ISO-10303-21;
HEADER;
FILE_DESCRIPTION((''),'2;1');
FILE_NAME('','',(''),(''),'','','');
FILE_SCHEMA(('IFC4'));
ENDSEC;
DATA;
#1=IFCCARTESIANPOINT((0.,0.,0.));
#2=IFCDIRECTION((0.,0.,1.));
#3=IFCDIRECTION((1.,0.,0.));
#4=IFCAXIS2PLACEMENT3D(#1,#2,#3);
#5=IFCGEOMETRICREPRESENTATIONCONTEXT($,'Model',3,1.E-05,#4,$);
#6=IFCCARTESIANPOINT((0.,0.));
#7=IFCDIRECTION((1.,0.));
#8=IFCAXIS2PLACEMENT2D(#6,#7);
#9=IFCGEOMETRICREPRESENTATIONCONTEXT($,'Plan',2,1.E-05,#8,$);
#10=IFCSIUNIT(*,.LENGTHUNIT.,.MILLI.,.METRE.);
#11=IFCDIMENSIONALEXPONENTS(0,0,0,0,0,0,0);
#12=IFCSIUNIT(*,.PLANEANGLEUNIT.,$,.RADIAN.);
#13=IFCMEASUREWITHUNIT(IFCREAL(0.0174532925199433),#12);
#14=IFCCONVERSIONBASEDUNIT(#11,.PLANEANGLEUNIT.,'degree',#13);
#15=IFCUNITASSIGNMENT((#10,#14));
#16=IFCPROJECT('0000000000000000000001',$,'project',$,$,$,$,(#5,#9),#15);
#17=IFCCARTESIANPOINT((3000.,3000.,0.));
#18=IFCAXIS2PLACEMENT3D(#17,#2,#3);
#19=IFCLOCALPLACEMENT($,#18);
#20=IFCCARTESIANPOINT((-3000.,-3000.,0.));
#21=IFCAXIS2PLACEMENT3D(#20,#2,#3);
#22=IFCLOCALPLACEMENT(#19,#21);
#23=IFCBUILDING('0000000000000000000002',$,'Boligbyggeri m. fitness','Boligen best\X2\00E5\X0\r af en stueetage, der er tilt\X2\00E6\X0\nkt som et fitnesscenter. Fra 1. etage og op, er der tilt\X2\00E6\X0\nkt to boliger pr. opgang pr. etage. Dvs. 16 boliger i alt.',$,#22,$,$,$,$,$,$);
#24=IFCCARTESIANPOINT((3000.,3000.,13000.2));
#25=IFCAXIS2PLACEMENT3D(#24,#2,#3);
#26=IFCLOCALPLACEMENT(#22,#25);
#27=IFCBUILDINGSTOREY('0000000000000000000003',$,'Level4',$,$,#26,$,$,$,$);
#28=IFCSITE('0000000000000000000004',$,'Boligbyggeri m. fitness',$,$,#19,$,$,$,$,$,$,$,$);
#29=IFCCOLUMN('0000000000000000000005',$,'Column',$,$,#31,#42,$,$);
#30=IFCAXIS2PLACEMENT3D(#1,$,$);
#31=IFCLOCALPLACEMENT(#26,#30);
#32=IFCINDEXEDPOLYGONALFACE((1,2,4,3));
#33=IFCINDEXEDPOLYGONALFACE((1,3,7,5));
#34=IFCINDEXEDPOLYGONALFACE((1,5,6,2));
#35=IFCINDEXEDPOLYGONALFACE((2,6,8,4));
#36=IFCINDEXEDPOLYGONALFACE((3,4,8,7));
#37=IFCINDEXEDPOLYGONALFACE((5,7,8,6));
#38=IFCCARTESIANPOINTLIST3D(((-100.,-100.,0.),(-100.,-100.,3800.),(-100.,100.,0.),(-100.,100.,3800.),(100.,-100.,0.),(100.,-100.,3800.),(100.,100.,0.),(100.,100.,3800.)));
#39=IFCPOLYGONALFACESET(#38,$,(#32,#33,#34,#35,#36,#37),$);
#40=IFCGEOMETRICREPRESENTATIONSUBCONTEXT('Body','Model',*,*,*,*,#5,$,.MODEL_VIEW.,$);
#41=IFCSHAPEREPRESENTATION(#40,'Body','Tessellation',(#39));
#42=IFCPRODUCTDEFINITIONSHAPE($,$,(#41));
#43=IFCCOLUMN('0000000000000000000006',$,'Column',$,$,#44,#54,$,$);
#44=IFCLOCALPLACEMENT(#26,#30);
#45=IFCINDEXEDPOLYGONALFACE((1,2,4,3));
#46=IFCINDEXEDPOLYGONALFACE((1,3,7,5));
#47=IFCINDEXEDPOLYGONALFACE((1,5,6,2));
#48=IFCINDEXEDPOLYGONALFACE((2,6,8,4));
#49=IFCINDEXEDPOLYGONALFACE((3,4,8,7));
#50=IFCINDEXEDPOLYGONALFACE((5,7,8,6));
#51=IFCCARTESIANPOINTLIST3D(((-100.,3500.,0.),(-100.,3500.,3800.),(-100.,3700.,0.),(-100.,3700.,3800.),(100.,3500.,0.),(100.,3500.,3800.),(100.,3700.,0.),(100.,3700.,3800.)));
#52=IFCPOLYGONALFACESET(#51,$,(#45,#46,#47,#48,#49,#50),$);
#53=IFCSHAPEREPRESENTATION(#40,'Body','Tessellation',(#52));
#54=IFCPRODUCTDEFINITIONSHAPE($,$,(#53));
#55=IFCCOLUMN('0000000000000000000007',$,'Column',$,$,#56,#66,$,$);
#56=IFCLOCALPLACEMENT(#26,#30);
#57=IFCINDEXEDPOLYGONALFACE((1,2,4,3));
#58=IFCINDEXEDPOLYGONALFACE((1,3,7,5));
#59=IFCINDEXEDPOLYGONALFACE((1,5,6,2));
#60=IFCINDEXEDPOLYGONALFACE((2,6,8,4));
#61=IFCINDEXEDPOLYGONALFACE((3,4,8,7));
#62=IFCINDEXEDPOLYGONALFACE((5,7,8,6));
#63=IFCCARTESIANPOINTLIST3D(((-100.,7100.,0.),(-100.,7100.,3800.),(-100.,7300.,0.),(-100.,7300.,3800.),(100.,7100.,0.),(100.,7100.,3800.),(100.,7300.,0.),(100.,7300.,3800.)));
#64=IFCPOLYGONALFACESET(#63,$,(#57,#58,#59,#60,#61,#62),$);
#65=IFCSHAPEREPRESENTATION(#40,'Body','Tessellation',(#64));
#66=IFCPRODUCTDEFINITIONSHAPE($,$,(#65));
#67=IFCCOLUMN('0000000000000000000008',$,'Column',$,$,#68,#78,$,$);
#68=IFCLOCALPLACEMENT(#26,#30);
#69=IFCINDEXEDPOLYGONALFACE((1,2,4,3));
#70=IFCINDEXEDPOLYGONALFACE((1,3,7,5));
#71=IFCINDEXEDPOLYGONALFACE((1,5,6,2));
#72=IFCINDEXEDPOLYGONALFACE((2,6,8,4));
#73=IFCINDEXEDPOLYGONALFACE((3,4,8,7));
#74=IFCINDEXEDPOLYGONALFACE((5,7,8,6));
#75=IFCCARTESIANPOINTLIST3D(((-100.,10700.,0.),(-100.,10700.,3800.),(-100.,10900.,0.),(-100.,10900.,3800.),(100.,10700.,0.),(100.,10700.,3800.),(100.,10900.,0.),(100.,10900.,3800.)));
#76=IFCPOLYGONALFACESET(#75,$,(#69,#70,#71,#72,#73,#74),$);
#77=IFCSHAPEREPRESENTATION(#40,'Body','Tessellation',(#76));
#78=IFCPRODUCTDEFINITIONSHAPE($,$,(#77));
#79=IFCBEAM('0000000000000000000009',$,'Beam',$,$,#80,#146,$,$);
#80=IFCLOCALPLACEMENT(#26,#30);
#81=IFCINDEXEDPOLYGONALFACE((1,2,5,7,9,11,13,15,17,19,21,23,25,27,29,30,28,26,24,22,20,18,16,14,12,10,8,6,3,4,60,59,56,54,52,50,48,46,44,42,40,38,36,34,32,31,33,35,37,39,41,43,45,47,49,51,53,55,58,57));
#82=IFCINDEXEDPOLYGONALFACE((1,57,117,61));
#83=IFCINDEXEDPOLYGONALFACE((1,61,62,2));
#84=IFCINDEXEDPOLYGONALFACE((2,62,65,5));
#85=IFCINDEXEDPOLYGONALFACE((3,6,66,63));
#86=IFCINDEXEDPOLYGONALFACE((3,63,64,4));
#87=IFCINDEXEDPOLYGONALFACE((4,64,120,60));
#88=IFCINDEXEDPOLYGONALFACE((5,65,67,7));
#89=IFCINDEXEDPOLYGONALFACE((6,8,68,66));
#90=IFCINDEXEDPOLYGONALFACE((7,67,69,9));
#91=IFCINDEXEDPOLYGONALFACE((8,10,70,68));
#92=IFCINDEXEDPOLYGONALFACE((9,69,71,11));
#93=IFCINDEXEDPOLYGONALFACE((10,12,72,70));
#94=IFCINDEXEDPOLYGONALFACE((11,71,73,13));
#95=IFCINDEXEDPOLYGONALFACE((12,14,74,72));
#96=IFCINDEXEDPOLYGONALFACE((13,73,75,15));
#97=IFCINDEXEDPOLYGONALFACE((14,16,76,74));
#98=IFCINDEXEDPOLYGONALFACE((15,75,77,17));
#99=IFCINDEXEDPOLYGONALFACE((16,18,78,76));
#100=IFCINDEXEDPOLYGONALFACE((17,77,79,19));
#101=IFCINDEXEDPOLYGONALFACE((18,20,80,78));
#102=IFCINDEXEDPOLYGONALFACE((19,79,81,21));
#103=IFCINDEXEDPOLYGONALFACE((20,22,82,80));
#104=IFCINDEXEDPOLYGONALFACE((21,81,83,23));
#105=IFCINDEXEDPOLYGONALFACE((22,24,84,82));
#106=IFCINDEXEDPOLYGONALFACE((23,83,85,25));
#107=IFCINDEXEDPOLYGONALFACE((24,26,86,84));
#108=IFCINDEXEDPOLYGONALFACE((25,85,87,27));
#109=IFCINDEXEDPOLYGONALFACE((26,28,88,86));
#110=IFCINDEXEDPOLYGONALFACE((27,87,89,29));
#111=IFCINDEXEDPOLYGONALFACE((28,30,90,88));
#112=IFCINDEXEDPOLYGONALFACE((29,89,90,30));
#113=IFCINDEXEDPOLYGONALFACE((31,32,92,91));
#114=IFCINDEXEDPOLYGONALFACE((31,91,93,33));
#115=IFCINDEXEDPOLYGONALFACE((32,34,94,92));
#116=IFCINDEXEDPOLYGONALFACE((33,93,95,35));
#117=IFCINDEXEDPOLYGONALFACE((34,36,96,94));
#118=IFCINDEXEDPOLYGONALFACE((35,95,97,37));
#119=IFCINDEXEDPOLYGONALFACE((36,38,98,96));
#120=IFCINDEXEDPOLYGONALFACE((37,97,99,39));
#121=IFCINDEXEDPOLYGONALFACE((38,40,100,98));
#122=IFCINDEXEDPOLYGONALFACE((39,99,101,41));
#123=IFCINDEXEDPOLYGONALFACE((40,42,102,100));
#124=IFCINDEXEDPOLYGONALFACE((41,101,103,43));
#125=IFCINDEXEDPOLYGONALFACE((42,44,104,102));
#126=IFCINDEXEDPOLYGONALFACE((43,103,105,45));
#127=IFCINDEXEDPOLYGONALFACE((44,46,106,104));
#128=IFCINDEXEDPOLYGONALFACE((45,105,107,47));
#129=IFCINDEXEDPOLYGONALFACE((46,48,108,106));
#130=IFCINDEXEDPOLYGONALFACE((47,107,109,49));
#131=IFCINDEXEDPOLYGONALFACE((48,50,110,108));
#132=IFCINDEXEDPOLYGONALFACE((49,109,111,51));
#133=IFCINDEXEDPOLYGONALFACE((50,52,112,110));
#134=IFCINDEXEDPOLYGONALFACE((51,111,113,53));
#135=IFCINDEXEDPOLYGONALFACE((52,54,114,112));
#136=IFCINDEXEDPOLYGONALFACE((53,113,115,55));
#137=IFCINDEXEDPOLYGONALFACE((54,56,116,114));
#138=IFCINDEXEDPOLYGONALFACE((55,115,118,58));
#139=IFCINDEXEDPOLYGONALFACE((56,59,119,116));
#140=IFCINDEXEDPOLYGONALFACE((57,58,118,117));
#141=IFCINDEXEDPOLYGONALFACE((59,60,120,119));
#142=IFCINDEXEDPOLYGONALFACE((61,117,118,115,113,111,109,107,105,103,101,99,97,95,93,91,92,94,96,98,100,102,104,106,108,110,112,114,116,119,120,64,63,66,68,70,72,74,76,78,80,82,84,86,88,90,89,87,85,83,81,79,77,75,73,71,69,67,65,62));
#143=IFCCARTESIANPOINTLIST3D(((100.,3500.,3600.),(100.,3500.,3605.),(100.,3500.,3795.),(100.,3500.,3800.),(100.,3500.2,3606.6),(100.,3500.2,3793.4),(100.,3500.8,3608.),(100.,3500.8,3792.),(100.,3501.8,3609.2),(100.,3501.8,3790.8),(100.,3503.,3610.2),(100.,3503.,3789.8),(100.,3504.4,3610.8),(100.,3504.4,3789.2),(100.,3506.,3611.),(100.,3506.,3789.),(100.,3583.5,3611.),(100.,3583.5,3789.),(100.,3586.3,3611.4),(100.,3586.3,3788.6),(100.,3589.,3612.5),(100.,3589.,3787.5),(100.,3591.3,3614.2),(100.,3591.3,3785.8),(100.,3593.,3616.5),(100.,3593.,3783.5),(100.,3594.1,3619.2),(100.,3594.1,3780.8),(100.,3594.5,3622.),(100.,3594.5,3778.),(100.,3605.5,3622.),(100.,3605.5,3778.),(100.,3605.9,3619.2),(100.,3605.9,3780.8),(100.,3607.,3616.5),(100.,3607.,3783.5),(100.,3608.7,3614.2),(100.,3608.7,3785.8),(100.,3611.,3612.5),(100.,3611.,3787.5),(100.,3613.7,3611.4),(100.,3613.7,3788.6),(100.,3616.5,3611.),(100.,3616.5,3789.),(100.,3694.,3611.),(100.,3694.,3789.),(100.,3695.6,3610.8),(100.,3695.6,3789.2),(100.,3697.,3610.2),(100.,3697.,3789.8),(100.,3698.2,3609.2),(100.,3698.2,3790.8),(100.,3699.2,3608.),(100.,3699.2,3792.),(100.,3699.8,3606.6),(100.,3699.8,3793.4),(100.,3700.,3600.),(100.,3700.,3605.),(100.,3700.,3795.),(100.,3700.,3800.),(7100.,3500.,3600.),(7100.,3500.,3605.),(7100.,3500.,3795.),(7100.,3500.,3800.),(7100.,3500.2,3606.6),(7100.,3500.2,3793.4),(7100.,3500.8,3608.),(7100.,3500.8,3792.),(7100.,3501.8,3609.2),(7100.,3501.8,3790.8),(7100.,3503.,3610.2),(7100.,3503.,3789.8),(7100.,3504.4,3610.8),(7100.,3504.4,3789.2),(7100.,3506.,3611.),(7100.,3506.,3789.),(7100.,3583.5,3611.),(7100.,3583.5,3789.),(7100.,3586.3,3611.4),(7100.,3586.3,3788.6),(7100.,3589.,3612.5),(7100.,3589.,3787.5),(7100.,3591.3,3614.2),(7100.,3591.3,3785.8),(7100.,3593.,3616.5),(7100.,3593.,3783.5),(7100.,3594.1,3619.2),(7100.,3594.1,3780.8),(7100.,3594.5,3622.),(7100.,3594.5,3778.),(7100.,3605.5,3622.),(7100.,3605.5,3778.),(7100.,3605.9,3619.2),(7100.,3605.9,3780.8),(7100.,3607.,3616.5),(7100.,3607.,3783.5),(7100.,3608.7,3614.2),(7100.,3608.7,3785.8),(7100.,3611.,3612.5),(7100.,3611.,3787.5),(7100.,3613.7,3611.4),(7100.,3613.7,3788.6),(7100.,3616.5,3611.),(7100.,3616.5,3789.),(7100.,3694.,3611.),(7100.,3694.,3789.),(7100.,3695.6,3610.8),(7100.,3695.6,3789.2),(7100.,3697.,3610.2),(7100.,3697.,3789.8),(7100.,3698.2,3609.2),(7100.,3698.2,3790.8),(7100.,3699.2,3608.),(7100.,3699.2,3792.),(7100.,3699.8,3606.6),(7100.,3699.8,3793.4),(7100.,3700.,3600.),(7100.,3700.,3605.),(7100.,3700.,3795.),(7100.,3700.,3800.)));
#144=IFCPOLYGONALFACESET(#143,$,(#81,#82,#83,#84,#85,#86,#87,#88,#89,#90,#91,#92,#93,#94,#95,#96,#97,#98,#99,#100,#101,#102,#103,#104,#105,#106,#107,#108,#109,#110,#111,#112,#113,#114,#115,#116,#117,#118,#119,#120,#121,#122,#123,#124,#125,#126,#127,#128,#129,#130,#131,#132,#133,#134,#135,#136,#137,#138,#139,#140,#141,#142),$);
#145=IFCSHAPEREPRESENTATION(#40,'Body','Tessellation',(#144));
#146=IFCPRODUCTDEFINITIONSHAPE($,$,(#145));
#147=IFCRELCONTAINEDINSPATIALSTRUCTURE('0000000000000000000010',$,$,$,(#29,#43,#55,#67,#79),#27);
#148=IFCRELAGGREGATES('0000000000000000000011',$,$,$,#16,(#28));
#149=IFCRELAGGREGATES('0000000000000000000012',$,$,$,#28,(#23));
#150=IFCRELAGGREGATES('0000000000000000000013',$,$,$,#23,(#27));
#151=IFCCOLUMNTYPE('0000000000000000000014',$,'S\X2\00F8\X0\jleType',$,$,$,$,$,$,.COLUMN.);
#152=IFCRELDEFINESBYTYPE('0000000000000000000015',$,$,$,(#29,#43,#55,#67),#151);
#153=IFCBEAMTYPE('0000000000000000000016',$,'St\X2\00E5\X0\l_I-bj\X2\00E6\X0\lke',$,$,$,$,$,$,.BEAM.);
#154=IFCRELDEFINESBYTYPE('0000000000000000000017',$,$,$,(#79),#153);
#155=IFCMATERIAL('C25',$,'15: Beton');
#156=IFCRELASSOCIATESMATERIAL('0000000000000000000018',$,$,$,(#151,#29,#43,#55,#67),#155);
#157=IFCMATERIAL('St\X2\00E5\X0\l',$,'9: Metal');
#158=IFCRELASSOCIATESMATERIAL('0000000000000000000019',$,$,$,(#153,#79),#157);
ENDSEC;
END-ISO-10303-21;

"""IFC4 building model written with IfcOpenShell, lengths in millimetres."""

from ifc_helpers import new_model, entity, si_unit, converted_unit, frame, origin_with_axes, origin_2d_with_axis, place, context, subcontext, project, spatial, rectangle, i_section, extrude, material, material_profile, profile_set, profile_usage, type_object, element, save


model = new_model("IFC4")

# Units and contexts
model_context = context("Model", 3, precision=1e-05, world=origin_with_axes())
plan_context = context("Plan", 2, precision=1e-05, world=origin_2d_with_axis())
body_context = subcontext(model_context, "Body", "Model", "MODEL_VIEW")
ifc_project = project(units=[si_unit("LENGTHUNIT", "METRE", prefix="MILLI"), converted_unit("PLANEANGLEUNIT", "degree", entity("IfcReal", 0.0174532925199433), si_unit("PLANEANGLEUNIT", "RADIAN"), dimensions=[0, 0, 0, 0, 0, 0, 0])], contexts=[model_context, plan_context])

# Site, building, storey
site_placement = place(None, frame((3000.0, 3000.0, 0.0), z_axis=(0.0, 0.0, 1.0), x_axis=(1.0, 0.0, 0.0)))
site = spatial("IfcSite", under=ifc_project, at=site_placement, Name="Boligbyggeri m. fitness")
building_placement = place(site_placement, frame((-3000.0, -3000.0, 0.0), z_axis=(0.0, 0.0, 1.0), x_axis=(1.0, 0.0, 0.0)))
building = spatial("IfcBuilding", under=site, at=building_placement, Name="Boligbyggeri m. fitness", Description="Boligen består af en stueetage, der er tiltænkt som et fitnesscenter. Fra 1. etage og op, er der tiltænkt to boliger pr. opgang pr. etage. Dvs. 16 boliger i alt.")
storey_placement = place(building_placement, frame((3000.0, 3000.0, 13000.2), z_axis=(0.0, 0.0, 1.0), x_axis=(1.0, 0.0, 0.0)))
storey = spatial("IfcBuildingStorey", under=building, at=storey_placement, Name="Level4")

# Columns
ifc_material_1 = material(Name="C25", Category="15: Beton")
ifc_material_profile_1 = material_profile(ifc_material_1, rectangle(XDim=200.0, YDim=200.0), Name="SøjleBeton", Category="15: Beton")
ifc_profile_set_1 = profile_set([ifc_material_profile_1], Name="200x200")
ifc_profile_usage_1 = profile_usage(ifc_profile_set_1, cardinal=5)
column_type = type_object("IfcColumnType", Name="SøjleType", PredefinedType="COLUMN", material=ifc_profile_set_1)
column_1_placement = place(storey_placement, frame((0.0, 0.0, 0.0), z_axis=(0.0, 0.0, 1.0), x_axis=(1.0, 0.0, 0.0)))
element("IfcColumn", 1, at=column_1_placement, inside=storey, type_object=column_type, material=ifc_profile_usage_1, Name="Column", context=body_context, shape_type="SweptSolid", body=[
    extrude(rectangle(XDim=200.0, YDim=200.0), origin_with_axes(), (0.0, 0.0, 1.0), 3800.0),
])
ifc_profile_usage_2 = profile_usage(ifc_profile_set_1, cardinal=5)
column_2_placement = place(storey_placement, frame((0.0, 3600.0, 0.0), z_axis=(0.0, 0.0, 1.0), x_axis=(1.0, 0.0, 0.0)))
element("IfcColumn", 2, at=column_2_placement, inside=storey, type_object=column_type, material=ifc_profile_usage_2, Name="Column", context=body_context, shape_type="SweptSolid", body=[
    extrude(rectangle(XDim=200.0, YDim=200.0), origin_with_axes(), (0.0, 0.0, 1.0), 3800.0),
])
ifc_profile_usage_3 = profile_usage(ifc_profile_set_1, cardinal=5)
column_3_placement = place(storey_placement, frame((0.0, 7200.0, 0.0), z_axis=(0.0, 0.0, 1.0), x_axis=(1.0, 0.0, 0.0)))
element("IfcColumn", 3, at=column_3_placement, inside=storey, type_object=column_type, material=ifc_profile_usage_3, Name="Column", context=body_context, shape_type="SweptSolid", body=[
    extrude(rectangle(XDim=200.0, YDim=200.0), origin_with_axes(), (0.0, 0.0, 1.0), 3800.0),
])
ifc_profile_usage_4 = profile_usage(ifc_profile_set_1, cardinal=5)
column_4_placement = place(storey_placement, frame((0.0, 10800.0, 0.0), z_axis=(0.0, 0.0, 1.0), x_axis=(1.0, 0.0, 0.0)))
element("IfcColumn", 4, at=column_4_placement, inside=storey, type_object=column_type, material=ifc_profile_usage_4, Name="Column", context=body_context, shape_type="SweptSolid", body=[
    extrude(rectangle(XDim=200.0, YDim=200.0), origin_with_axes(), (0.0, 0.0, 1.0), 3800.0),
])

# Beam
ifc_material_2 = material(Name="Stål", Category="9: Metal")
ifc_material_profile_2 = material_profile(ifc_material_2, i_section(OverallWidth=200.0, OverallDepth=200.0, WebThickness=11.0, FlangeThickness=11.0, FilletRadius=11.0, FlangeEdgeRadius=6.0), Name="Stål", Category="9: Metal")
ifc_profile_set_2 = profile_set([ifc_material_profile_2], Name="NY_I-Profil")
ifc_profile_usage_5 = profile_usage(ifc_profile_set_2, cardinal=7)
beam_type = type_object("IfcBeamType", Name="Stål_I-bjælke", PredefinedType="BEAM", material=ifc_profile_set_2)
beam_1_placement = place(storey_placement, frame((100.0, 3700.0, 3800.0), z_axis=(1.0, 0.0, 0.0), x_axis=(0.0, 1.0, 0.0)))
element("IfcBeam", 5, at=beam_1_placement, inside=storey, type_object=beam_type, material=ifc_profile_usage_5, Name="Beam", context=body_context, shape_type="SweptSolid", body=[
    extrude(i_section(OverallWidth=200.0, OverallDepth=200.0, WebThickness=11.0, FlangeThickness=11.0, FilletRadius=11.0, FlangeEdgeRadius=6.0), frame((-100.0, -100.0, 0.0), z_axis=(0.0, 0.0, 1.0), x_axis=(1.0, 0.0, 0.0)), (0.0, 0.0, 1.0), 7000.0),
])

save(model, "model.ifc")
